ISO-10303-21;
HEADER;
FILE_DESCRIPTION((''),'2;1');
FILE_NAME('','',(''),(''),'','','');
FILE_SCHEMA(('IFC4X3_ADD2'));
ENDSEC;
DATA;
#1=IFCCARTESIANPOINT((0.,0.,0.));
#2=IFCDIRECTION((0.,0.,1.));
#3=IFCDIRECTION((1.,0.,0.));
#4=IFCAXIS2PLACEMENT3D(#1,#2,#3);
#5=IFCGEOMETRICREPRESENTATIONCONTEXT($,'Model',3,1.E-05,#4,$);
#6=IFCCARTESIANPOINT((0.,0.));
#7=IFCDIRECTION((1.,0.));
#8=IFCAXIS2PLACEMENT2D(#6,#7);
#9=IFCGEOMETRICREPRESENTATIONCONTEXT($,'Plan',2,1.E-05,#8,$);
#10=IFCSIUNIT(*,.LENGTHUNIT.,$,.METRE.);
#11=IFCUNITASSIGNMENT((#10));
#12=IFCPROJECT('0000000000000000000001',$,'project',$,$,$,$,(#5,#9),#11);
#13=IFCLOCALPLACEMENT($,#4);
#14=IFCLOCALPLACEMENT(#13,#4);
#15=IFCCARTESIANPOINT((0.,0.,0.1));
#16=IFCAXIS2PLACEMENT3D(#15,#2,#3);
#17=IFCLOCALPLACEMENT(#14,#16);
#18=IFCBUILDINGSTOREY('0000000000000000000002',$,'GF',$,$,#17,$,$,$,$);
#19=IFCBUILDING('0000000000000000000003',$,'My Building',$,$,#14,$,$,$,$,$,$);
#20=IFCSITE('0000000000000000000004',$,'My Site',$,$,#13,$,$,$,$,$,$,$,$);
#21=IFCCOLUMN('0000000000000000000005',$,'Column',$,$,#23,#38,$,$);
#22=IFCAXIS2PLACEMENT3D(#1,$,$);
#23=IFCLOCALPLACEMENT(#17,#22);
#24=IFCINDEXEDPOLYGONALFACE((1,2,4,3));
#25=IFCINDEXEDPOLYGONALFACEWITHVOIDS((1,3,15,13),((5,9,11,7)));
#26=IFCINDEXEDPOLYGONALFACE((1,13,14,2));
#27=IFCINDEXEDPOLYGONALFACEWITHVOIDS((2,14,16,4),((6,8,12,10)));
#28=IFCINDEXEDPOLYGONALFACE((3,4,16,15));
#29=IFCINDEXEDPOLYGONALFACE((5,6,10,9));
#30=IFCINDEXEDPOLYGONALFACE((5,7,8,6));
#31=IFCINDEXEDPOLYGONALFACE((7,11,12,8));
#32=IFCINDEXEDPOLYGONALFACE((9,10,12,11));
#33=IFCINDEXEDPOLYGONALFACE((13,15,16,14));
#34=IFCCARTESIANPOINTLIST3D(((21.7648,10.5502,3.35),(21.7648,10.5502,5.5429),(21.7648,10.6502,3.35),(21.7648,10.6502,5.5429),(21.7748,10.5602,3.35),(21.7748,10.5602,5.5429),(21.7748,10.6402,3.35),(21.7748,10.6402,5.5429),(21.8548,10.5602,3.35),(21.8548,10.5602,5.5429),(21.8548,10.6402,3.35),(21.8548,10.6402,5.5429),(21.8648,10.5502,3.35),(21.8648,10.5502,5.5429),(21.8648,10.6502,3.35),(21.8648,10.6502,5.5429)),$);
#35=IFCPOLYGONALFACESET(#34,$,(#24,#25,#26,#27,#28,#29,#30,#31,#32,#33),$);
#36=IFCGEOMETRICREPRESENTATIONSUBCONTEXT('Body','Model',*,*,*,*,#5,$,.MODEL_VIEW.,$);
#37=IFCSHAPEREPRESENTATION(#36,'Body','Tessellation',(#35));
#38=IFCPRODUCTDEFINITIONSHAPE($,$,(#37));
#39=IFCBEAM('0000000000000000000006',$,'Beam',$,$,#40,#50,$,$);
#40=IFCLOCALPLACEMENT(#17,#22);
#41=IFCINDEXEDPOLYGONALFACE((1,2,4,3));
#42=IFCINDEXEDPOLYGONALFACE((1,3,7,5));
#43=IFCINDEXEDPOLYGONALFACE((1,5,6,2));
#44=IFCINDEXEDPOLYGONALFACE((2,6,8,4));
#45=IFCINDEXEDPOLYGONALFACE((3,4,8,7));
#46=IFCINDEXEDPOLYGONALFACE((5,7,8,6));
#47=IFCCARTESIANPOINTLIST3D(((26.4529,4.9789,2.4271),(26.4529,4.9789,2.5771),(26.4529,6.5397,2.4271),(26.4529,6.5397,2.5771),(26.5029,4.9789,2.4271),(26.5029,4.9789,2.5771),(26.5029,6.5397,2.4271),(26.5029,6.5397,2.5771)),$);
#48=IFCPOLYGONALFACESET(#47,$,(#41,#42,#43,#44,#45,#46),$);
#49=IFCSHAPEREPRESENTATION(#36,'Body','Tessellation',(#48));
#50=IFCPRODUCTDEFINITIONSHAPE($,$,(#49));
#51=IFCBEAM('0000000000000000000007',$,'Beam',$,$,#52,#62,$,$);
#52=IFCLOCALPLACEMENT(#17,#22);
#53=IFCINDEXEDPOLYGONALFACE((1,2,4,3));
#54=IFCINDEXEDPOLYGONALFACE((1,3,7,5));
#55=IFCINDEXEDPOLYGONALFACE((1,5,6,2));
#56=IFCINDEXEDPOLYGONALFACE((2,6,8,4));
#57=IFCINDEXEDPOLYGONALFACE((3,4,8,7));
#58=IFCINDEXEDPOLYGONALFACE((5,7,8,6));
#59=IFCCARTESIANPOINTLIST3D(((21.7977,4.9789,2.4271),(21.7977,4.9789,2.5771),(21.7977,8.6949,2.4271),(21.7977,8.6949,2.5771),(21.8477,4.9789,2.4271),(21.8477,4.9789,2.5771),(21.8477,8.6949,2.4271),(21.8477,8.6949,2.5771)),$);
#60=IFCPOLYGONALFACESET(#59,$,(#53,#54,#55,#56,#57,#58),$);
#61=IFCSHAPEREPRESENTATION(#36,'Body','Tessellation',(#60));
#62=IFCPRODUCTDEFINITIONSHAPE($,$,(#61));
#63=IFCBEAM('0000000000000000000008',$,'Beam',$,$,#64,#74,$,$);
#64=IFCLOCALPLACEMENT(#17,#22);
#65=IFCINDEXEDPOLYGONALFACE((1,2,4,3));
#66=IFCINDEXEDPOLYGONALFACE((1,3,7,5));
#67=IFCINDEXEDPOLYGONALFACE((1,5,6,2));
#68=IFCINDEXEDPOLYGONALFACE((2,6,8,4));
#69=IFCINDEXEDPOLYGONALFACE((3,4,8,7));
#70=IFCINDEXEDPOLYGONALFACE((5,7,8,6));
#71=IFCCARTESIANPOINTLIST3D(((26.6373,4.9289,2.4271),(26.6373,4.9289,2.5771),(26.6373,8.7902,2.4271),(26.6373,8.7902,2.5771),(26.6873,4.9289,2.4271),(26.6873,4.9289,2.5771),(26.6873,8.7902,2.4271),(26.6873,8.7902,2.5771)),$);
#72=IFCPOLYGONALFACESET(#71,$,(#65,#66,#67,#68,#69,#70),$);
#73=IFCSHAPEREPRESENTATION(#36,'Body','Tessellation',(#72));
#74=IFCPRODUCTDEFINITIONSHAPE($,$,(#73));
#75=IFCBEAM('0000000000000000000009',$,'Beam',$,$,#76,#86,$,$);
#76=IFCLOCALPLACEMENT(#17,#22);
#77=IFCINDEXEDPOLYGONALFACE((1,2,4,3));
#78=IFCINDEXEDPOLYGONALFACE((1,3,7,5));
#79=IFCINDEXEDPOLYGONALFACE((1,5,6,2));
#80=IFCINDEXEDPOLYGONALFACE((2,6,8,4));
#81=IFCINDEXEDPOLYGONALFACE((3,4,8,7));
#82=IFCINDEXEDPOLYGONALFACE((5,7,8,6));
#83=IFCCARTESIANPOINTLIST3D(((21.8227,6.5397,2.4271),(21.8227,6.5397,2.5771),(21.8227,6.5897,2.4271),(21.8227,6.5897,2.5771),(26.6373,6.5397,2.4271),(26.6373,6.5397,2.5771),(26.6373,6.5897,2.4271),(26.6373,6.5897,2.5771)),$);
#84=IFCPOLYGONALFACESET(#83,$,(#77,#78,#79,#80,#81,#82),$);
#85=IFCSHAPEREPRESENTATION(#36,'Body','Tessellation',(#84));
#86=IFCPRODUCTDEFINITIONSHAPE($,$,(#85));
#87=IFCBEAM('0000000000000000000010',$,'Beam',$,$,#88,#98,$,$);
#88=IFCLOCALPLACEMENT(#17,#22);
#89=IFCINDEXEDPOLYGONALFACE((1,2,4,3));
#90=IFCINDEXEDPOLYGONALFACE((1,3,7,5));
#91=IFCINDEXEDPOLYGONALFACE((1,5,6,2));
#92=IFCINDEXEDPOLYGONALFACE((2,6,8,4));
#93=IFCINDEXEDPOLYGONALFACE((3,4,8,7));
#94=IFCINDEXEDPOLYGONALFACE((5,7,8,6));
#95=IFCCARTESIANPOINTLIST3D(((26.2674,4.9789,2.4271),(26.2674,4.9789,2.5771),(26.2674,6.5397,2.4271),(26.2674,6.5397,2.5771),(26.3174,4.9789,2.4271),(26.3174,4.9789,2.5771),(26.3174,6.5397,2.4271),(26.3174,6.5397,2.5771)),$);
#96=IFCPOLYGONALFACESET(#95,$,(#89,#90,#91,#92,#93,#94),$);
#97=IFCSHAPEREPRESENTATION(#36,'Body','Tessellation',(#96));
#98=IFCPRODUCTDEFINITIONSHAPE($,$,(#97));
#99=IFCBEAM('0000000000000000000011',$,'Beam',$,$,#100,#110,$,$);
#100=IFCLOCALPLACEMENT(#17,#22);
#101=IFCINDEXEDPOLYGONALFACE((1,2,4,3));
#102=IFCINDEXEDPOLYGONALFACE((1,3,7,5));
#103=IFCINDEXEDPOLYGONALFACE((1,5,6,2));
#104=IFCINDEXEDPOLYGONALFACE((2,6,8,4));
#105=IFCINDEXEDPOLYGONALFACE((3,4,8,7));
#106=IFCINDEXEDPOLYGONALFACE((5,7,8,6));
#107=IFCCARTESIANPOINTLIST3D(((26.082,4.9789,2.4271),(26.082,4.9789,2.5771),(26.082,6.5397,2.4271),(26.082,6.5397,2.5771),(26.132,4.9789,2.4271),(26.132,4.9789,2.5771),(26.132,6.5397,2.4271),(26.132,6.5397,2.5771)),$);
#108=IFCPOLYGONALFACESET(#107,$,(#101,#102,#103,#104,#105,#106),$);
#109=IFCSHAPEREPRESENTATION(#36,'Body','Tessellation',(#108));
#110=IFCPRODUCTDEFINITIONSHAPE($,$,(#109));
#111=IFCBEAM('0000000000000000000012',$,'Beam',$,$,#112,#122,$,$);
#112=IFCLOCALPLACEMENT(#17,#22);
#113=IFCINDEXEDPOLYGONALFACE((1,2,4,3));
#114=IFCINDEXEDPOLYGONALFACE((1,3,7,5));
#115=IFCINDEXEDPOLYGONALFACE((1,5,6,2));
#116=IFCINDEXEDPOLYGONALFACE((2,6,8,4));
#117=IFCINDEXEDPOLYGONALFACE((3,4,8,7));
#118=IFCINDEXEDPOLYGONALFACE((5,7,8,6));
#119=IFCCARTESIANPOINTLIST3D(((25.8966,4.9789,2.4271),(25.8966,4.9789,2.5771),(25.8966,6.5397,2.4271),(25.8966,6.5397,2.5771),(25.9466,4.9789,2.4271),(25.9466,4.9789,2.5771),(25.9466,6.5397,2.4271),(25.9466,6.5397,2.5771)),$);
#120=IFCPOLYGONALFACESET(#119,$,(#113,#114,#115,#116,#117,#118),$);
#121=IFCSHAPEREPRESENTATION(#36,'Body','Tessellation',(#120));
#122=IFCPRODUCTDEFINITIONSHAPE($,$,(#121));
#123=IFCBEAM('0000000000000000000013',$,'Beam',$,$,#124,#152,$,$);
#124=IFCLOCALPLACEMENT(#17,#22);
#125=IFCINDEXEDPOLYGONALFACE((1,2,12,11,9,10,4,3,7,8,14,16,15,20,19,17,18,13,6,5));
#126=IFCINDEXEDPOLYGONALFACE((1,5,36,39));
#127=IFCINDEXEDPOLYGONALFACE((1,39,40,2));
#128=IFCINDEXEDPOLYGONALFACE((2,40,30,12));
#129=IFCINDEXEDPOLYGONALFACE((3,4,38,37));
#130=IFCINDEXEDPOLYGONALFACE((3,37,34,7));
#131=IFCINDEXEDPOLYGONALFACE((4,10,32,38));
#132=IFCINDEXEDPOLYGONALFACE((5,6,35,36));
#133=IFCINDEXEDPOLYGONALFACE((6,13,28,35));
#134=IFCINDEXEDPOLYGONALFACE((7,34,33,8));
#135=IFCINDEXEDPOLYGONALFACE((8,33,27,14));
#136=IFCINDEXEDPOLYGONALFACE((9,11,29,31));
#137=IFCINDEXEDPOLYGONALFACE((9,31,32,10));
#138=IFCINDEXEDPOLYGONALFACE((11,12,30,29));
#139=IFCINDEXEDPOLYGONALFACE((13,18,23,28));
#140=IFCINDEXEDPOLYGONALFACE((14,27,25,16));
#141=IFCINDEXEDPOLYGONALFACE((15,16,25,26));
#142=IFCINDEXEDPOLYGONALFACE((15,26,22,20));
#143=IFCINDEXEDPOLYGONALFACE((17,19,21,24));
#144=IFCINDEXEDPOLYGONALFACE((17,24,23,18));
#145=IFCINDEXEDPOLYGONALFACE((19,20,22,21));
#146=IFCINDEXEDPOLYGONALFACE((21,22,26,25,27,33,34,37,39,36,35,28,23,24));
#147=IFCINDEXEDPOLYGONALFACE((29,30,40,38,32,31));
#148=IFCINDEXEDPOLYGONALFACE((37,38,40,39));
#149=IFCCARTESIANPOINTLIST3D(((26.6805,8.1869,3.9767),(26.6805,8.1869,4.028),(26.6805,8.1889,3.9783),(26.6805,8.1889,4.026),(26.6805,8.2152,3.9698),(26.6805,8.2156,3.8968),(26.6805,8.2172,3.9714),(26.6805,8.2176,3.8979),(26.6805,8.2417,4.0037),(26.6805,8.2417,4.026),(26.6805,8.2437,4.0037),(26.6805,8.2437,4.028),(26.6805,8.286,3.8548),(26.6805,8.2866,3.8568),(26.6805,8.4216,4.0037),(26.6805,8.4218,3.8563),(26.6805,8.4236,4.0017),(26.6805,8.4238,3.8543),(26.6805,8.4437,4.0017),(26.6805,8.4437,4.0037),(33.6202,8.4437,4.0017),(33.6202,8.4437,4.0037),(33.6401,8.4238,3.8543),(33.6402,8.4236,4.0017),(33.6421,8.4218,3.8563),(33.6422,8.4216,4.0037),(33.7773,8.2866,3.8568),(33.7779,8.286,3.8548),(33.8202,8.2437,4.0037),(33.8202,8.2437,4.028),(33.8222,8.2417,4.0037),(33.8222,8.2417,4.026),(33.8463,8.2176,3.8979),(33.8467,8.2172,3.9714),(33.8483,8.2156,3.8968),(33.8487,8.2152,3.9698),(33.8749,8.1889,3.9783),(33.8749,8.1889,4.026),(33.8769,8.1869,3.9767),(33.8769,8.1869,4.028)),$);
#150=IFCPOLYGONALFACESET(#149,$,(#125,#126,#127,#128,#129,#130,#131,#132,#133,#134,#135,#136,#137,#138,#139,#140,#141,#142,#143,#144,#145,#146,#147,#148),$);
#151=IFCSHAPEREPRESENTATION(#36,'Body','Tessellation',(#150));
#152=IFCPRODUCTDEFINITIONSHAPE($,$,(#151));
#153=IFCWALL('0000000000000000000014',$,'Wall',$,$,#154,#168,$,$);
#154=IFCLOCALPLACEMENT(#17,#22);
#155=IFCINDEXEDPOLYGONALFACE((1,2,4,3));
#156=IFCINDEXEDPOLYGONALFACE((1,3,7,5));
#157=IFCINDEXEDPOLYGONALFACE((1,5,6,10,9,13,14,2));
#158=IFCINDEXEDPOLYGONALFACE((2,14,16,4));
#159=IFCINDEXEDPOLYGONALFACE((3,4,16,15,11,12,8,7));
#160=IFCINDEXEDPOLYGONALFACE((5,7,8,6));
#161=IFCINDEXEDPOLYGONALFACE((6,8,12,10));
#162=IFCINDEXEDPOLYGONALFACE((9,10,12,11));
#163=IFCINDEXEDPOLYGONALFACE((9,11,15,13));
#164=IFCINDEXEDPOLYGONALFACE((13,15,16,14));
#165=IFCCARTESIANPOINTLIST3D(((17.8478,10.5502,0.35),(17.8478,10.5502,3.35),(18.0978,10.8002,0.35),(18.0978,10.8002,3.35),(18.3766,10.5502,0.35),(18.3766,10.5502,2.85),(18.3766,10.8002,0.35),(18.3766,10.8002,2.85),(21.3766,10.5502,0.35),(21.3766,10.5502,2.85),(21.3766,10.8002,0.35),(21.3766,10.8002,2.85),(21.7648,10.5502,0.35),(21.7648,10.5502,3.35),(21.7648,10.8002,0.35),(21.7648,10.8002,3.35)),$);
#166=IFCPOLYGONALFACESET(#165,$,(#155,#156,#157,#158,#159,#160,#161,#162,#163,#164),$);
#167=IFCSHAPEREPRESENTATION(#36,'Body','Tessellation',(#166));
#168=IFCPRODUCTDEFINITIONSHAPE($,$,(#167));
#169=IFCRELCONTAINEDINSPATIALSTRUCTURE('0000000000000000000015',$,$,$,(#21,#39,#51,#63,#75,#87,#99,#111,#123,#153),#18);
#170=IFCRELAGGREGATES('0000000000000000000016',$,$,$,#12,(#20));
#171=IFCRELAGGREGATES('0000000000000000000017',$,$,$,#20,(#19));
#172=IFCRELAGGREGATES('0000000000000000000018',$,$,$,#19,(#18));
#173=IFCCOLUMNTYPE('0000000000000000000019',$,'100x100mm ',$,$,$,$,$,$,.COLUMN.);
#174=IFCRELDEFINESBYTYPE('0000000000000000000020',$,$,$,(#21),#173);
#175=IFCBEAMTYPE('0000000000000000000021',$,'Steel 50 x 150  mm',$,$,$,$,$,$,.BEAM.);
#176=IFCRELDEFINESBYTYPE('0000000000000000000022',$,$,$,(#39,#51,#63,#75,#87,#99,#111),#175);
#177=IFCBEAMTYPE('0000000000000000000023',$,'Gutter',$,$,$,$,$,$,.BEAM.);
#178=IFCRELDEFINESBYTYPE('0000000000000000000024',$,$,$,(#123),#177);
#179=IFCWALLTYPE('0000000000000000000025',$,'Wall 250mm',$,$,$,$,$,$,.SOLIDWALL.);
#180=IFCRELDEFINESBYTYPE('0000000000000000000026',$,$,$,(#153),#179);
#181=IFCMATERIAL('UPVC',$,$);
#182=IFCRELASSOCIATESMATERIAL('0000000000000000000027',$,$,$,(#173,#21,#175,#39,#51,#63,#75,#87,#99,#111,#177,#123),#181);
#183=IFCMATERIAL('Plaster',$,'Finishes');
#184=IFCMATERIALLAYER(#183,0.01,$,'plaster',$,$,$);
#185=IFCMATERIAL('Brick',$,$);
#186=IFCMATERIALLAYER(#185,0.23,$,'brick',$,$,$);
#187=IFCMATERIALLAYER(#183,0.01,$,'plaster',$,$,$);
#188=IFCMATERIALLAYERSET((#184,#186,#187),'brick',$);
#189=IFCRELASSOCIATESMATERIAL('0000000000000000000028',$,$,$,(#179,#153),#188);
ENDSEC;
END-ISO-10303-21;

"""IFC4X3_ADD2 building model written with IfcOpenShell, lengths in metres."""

from ifc_helpers import new_model, entity, si_unit, frame, origin_with_axes, origin_2d_with_axis, place, context, subcontext, project, spatial, line, indexed_curve, rectangle, hollow_rectangle, outline, extrude, clip, halfspace, shape, source, transform, mapped, material, layer, layer_set, layer_usage, material_profile, profile_set, profile_usage, type_object, element, save


model = new_model("IFC4X3_ADD2")

# Units and contexts
model_context = context("Model", 3, precision=1e-05, world=origin_with_axes())
plan_context = context("Plan", 2, precision=1e-05, world=origin_2d_with_axis())
body_context_1 = subcontext(model_context, "Body", "Model", "MODEL_VIEW")
body_context_2 = subcontext(plan_context, "Body", "Plan", "PLAN_VIEW")
ifc_project = project(units=[si_unit("LENGTHUNIT", "METRE")], contexts=[model_context, plan_context])

# Site, building, storey
site_placement = place(None, origin_with_axes())
site = spatial("IfcSite", under=ifc_project, at=site_placement, Name="My Site")
building_placement = place(site_placement, origin_with_axes())
building = spatial("IfcBuilding", under=site, at=building_placement, Name="My Building")
storey_placement = place(building_placement, frame((0.0, 0.0, 0.1), z_axis=(0.0, 0.0, 1.0), x_axis=(1.0, 0.0, 0.0)))
storey = spatial("IfcBuildingStorey", under=building, at=storey_placement, Name="GF")

# Column
ifc_material_1 = material(Name="UPVC")
ifc_material_profile_1 = material_profile(ifc_material_1, hollow_rectangle(XDim=0.1, YDim=0.1, WallThickness=0.01))
ifc_profile_set_1 = profile_set([ifc_material_profile_1])
ifc_profile_usage_1 = profile_usage(ifc_profile_set_1)
column_type = type_object("IfcColumnType", Name="100x100mm ", PredefinedType="COLUMN", material=ifc_profile_set_1)
column_placement = place(storey_placement, frame((21.8148, 10.6002, 3.35), z_axis=(0.0, 0.0, 1.0), x_axis=(0.0, -1.0, 0.0)))
element("IfcColumn", 1, at=column_placement, inside=storey, type_object=column_type, material=ifc_profile_usage_1, Name="Column", shapes=[
    shape(body_context_1, "Body", "SweptSolid", [extrude(hollow_rectangle(XDim=0.1, YDim=0.1, WallThickness=0.01), origin_with_axes(), (0.0, 0.0, 1.0), 2.1929)]),
    shape(body_context_2, "Body", "Annotation2D", [entity("IfcGeometricCurveSet", [entity("IfcIndexedPolyCurve", entity("IfcCartesianPointList2D", [[0.04, -0.04], [0.04, 0.04], [-0.04, 0.04], [-0.04, -0.04]]), [entity("IfcLineIndex", [1, 2, 3, 4, 1])]), entity("IfcIndexedPolyCurve", entity("IfcCartesianPointList2D", [[-0.05, -0.05], [-0.05, 0.05], [0.05, 0.05], [0.05, -0.05]]), [entity("IfcLineIndex", [1, 2, 3, 4, 1])])])]),
])

# Beams
ifc_material_profile_2 = material_profile(ifc_material_1, rectangle(XDim=0.05, YDim=0.15))
ifc_profile_set_2 = profile_set([ifc_material_profile_2])
ifc_profile_usage_2 = profile_usage(ifc_profile_set_2)
beam_type_1 = type_object("IfcBeamType", Name="Steel 50 x 150  mm", PredefinedType="BEAM", material=ifc_profile_set_2)
beam_1_placement = place(storey_placement, frame((26.4779, 6.5397, 2.5021), z_axis=(0.0, -1.0, 0.0), x_axis=(1.0, 0.0, 0.0)))
element("IfcBeam", 2, at=beam_1_placement, inside=storey, type_object=beam_type_1, material=ifc_profile_usage_2, Name="Beam", context=body_context_1, shape_type="SweptSolid", body=[
    extrude(rectangle(XDim=0.05, YDim=0.15), origin_with_axes(), (0.0, 0.0, 1.0), 1.5608),
])
ifc_profile_usage_3 = profile_usage(ifc_profile_set_2)
beam_2_placement = place(storey_placement, frame((21.8227, 8.6949, 2.5021), z_axis=(0.0, -1.0, 0.0), x_axis=(1.0, 0.0, 0.0)))
element("IfcBeam", 3, at=beam_2_placement, inside=storey, type_object=beam_type_1, material=ifc_profile_usage_3, Name="Beam", context=body_context_1, shape_type="SweptSolid", body=[
    extrude(rectangle(XDim=0.05, YDim=0.15), origin_with_axes(), (0.0, 0.0, 1.0), 3.716),
])
ifc_profile_usage_4 = profile_usage(ifc_profile_set_2)
beam_3_placement = place(storey_placement, frame((26.6623, 8.7902, 2.5021), z_axis=(0.0, -1.0, 0.0), x_axis=(1.0, 0.0, 0.0)))
element("IfcBeam", 4, at=beam_3_placement, inside=storey, type_object=beam_type_1, material=ifc_profile_usage_4, Name="Beam", context=body_context_1, shape_type="SweptSolid", body=[
    extrude(rectangle(XDim=0.05, YDim=0.15), origin_with_axes(), (0.0, 0.0, 1.0), 3.8613),
])
ifc_profile_usage_5 = profile_usage(ifc_profile_set_2)
beam_4_placement = place(storey_placement, frame((21.8227, 6.5647, 2.5021), z_axis=(1.0, 0.0, 0.0), x_axis=(0.0, 1.0, 0.0)))
element("IfcBeam", 5, at=beam_4_placement, inside=storey, type_object=beam_type_1, material=ifc_profile_usage_5, Name="Beam", context=body_context_1, shape_type="SweptSolid", body=[
    extrude(rectangle(XDim=0.05, YDim=0.15), origin_with_axes(), (0.0, 0.0, 1.0), 4.8146),
])
ifc_profile_usage_6 = profile_usage(ifc_profile_set_2)
beam_5_placement = place(storey_placement, frame((26.2924, 6.5397, 2.5021), z_axis=(0.0, -1.0, 0.0), x_axis=(1.0, 0.0, 0.0)))
element("IfcBeam", 6, at=beam_5_placement, inside=storey, type_object=beam_type_1, material=ifc_profile_usage_6, Name="Beam", context=body_context_1, shape_type="SweptSolid", body=[
    extrude(rectangle(XDim=0.05, YDim=0.15), origin_with_axes(), (0.0, 0.0, 1.0), 1.5608),
])
ifc_profile_usage_7 = profile_usage(ifc_profile_set_2)
beam_6_placement = place(storey_placement, frame((26.107, 6.5397, 2.5021), z_axis=(0.0, -1.0, 0.0), x_axis=(1.0, 0.0, 0.0)))
element("IfcBeam", 7, at=beam_6_placement, inside=storey, type_object=beam_type_1, material=ifc_profile_usage_7, Name="Beam", context=body_context_1, shape_type="SweptSolid", body=[
    extrude(rectangle(XDim=0.05, YDim=0.15), origin_with_axes(), (0.0, 0.0, 1.0), 1.5608),
])
ifc_profile_usage_8 = profile_usage(ifc_profile_set_2)
beam_7_placement = place(storey_placement, frame((25.9216, 6.5397, 2.5021), z_axis=(0.0, -1.0, 0.0), x_axis=(1.0, 0.0, 0.0)))
element("IfcBeam", 8, at=beam_7_placement, inside=storey, type_object=beam_type_1, material=ifc_profile_usage_8, Name="Beam", context=body_context_1, shape_type="SweptSolid", body=[
    extrude(rectangle(XDim=0.05, YDim=0.15), origin_with_axes(), (0.0, 0.0, 1.0), 1.5608),
])
ifc_material_profile_3 = material_profile(ifc_material_1, outline(indexed_curve([(0.0548, 0.1717), (0.002, 0.1717), (0.002, 0.124), (0.0303, 0.1171), (0.0307, 0.0436), (0.0996, 0.0025), (0.2349, 0.002), (0.2347, 0.1494), (0.2567, 0.1494), (0.2567, 0.1474), (0.2367, 0.1474), (0.2369, 0.0), (0.0991, 0.0005), (0.0287, 0.0425), (0.0283, 0.1155), (0.0, 0.1224), (0.0, 0.1737), (0.0568, 0.1737), (0.0568, 0.1494), (0.0548, 0.1494), (0.0548, 0.1717)])))
ifc_profile_set_3 = profile_set([ifc_material_profile_3])
ifc_profile_usage_9 = profile_usage(ifc_profile_set_3)
beam_type_2 = type_object("IfcBeamType", Name="Gutter", PredefinedType="BEAM", material=ifc_profile_set_3)
beam_8_placement = place(storey_placement, frame((26.6805, 8.1869, 3.8543), z_axis=(1.0, 0.0, 0.0), x_axis=(0.0, 1.0, 0.0)))
element("IfcBeam", 9, at=beam_8_placement, inside=storey, type_object=beam_type_2, material=ifc_profile_usage_9, Name="Beam", context=body_context_1, shape_type="Clipping", body=[
    clip(extrude(outline(indexed_curve([(0.0548, 0.1717), (0.002, 0.1717), (0.002, 0.124), (0.0303, 0.1171), (0.0307, 0.0436), (0.0996, 0.0025), (0.2349, 0.002), (0.2347, 0.1494), (0.2567, 0.1494), (0.2567, 0.1474), (0.2367, 0.1474), (0.2369, 0.0), (0.0991, 0.0005), (0.0287, 0.0425), (0.0283, 0.1155), (0.0, 0.1224), (0.0, 0.1737), (0.0568, 0.1737), (0.0568, 0.1494), (0.0548, 0.1494), (0.0548, 0.1717)])), origin_with_axes(), (0.0, 0.0, 1.0), 7.1965), halfspace(frame((0.0, -3.9543, 7.1965), z_axis=(0.70711, 0.0, 0.707104), x_axis=(0.0, -1.0, 0.0)), False)),
])

# Wall, opening
ifc_material_2 = material(Name="Plaster", Category="Finishes")
ifc_layer_1 = layer(ifc_material_2, 0.01, Name="plaster")
ifc_material_3 = material(Name="Brick")
ifc_layer_2 = layer(ifc_material_3, 0.23, Name="brick")
ifc_layer_3 = layer(ifc_material_2, 0.01, Name="plaster")
ifc_layer_set_1 = layer_set([ifc_layer_1, ifc_layer_2, ifc_layer_3], Name="brick")
ifc_layer_usage_1 = layer_usage(ifc_layer_set_1, "AXIS2", "POSITIVE", 0.0)
wall_type_1 = type_object("IfcWallType", Name="Wall 250mm", PredefinedType="SOLIDWALL", material=ifc_layer_set_1)
wall_1_placement = place(storey_placement, frame((21.7648, 10.8002, 0.35), z_axis=(0.0, 0.0, 1.0), x_axis=(-1.0, 0.0, 0.0)))
wall_1 = element("IfcWall", 10, at=wall_1_placement, inside=storey, type_object=wall_type_1, material=ifc_layer_usage_1, Name="Wall", context=body_context_1, shape_type="SweptSolid", body=[
    extrude(outline(indexed_curve([(0.0, 0.0), (0.0, 0.25), (3.917, 0.25), (3.667, 0.0)], segments=[line(1, 2, 3, 4, 1)])), origin_with_axes(), (0.0, 0.0, 1.0), 3.0),
])
shared_shape_1 = source(origin_with_axes(), body_context_1, "Body", "SweptSolid", [
    extrude(outline(indexed_curve([(0.0, 0.0), (3.0, 0.0), (3.0, 2.5), (0.0, 2.5)], segments=[line(1, 2, 3, 4, 1)])), frame((0.0, -0.6, 0.0), z_axis=(0.0, -1.0, 0.0), x_axis=(1.0, 0.0, 0.0)), (0.0, 0.0, -1.0), 1.2),
])
opening_placement = place(wall_1_placement, frame((0.3882, 0.0, 0.0), z_axis=(0.0, 0.0, 1.0), x_axis=(1.0, 0.0, 0.0)))
element("IfcOpeningElement", 11, at=opening_placement, cuts=wall_1, PredefinedType="OPENING", context=body_context_1, shape_type="MappedRepresentation", body=[
    mapped(shared_shape_1, transform((0.0, 0.0, 0.0), x_axis=(1.0, 0.0, 0.0), y_axis=(0.0, 1.0, 0.0), z_axis=(0.0, 0.0, 1.0), scale=1.0)),
])

save(model, "model.ifc")
